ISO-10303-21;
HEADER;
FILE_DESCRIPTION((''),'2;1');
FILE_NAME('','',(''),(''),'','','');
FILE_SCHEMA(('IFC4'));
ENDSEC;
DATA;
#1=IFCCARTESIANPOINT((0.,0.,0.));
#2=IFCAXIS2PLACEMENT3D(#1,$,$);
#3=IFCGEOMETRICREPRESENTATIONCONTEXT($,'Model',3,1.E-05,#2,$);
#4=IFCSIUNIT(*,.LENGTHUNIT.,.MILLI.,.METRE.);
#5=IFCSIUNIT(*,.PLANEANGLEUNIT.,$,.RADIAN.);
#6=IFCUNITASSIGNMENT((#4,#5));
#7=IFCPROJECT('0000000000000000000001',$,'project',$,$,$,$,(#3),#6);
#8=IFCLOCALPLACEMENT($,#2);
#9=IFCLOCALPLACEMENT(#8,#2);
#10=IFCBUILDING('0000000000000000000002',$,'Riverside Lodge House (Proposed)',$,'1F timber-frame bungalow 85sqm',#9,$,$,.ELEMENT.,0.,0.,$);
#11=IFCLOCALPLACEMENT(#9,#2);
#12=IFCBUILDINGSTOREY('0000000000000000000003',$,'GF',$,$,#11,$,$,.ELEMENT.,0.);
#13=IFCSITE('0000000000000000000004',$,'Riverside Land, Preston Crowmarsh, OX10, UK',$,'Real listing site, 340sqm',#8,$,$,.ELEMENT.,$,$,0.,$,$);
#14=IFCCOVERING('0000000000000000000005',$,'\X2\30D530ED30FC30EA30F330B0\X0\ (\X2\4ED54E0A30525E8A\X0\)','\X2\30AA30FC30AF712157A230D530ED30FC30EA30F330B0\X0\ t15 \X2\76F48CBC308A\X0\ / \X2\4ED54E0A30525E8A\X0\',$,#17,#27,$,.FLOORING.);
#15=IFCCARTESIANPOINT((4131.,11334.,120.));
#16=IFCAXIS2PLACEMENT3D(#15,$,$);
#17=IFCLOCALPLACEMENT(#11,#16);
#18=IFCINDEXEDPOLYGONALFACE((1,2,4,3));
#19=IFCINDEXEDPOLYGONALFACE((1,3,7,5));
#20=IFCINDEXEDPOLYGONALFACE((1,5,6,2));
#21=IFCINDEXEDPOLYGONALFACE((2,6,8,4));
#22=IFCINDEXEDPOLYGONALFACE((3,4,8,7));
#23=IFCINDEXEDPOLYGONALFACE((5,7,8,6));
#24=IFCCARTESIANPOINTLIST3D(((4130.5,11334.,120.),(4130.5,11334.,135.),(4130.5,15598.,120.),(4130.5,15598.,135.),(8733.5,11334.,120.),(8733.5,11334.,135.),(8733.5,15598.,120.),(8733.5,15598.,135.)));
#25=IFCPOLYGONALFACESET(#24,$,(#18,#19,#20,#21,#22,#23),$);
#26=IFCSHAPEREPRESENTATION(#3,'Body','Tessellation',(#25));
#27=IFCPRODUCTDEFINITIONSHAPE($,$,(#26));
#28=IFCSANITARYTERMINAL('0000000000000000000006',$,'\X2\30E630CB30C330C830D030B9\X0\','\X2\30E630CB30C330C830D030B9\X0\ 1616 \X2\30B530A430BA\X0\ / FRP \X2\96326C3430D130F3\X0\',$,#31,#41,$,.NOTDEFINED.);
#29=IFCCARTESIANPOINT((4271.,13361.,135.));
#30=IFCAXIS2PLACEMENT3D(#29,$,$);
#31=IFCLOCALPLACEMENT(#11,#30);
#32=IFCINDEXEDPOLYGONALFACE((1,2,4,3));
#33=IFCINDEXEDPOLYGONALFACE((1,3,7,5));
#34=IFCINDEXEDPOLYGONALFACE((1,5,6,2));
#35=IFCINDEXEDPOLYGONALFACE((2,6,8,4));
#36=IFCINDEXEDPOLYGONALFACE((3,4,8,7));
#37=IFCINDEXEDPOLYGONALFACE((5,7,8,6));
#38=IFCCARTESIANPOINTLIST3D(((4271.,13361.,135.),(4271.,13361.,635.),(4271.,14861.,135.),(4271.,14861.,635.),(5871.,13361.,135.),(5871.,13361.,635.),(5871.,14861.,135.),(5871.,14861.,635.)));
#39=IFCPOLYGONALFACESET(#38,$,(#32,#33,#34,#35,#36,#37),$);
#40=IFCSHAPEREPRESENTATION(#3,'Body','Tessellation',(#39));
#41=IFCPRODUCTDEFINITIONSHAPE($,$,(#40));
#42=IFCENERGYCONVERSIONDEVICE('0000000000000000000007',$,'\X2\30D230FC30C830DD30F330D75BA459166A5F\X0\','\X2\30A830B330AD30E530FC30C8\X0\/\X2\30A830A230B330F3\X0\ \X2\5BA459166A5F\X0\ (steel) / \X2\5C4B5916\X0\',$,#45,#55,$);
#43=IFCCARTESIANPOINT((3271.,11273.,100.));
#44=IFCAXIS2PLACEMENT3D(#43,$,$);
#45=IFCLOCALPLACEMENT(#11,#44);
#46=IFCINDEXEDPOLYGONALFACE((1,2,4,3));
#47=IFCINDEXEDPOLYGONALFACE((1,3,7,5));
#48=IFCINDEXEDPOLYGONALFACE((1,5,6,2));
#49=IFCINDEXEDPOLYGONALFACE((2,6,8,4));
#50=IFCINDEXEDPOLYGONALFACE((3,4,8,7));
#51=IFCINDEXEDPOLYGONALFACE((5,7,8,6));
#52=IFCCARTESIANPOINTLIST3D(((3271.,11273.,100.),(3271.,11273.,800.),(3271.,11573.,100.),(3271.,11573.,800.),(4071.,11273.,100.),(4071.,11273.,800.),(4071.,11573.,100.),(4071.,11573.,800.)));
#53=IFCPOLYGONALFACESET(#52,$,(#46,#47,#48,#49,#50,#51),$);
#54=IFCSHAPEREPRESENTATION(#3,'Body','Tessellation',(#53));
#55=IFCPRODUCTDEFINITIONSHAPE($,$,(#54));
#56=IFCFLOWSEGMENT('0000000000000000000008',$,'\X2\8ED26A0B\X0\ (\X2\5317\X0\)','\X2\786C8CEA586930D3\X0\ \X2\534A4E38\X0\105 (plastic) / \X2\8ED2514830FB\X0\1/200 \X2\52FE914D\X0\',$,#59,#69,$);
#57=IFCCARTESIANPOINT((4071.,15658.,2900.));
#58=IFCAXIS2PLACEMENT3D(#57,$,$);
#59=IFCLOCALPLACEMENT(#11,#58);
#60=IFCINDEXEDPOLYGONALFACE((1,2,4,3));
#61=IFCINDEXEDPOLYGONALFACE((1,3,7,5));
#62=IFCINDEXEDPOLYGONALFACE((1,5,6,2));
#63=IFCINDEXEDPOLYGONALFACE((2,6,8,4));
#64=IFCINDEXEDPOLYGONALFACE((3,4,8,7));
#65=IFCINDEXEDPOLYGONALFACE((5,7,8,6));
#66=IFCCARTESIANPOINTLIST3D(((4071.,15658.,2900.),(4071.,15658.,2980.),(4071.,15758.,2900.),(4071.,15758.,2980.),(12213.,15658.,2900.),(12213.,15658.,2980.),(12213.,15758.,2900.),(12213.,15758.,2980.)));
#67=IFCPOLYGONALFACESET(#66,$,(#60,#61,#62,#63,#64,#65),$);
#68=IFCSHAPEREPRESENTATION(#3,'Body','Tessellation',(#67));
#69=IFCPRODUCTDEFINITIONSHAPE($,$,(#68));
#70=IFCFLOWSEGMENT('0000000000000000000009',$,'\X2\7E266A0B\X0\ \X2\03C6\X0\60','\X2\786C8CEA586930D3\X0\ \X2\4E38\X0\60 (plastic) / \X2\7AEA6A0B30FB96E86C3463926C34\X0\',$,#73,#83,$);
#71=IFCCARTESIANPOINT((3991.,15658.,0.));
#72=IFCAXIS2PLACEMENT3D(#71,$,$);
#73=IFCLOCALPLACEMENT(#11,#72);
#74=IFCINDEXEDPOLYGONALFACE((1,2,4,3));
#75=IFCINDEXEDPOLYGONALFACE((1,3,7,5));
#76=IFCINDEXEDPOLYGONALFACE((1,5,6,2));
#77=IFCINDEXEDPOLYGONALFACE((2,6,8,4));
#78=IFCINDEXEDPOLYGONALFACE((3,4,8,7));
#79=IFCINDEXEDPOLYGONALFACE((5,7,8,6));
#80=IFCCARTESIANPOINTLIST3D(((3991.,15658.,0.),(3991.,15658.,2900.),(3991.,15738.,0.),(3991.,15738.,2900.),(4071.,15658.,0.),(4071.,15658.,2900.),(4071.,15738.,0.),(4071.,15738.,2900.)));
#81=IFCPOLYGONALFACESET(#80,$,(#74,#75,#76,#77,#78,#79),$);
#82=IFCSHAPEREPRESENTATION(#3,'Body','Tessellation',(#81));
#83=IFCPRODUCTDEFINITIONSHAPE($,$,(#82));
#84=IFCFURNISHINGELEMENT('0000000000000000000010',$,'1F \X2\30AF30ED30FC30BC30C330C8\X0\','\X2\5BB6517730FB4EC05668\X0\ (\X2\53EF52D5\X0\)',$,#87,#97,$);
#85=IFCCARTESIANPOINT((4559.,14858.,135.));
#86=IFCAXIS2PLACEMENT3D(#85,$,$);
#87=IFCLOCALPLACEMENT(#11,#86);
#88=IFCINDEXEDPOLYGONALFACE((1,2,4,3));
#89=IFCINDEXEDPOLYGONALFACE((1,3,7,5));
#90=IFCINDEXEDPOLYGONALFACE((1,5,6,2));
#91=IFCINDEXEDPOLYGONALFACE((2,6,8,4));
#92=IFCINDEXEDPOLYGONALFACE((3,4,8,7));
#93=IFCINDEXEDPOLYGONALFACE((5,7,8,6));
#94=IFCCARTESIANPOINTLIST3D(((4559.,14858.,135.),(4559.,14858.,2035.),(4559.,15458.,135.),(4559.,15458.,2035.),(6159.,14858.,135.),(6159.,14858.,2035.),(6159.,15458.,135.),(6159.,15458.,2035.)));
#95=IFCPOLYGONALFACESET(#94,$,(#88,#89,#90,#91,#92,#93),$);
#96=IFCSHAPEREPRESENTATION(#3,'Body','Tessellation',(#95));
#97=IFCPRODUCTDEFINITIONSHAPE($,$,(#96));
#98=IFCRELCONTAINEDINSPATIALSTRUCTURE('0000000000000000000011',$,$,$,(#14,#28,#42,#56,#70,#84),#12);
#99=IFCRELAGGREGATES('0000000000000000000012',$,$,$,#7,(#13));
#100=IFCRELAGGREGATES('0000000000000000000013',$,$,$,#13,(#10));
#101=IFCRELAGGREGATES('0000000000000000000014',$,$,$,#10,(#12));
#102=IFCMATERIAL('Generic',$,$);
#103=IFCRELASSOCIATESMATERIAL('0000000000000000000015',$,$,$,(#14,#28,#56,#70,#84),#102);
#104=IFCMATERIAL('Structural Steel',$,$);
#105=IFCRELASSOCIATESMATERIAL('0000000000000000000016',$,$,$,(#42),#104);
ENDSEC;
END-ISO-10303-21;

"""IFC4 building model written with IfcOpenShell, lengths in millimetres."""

from ifc_helpers import new_model, si_unit, frame, frame_2d, origin, place, context, project, spatial, rectangle, extrude, material, element, save


model = new_model("IFC4")

# Units and contexts
model_context = context("Model", 3, precision=1e-05, world=origin())
ifc_project = project(units=[si_unit("LENGTHUNIT", "METRE", prefix="MILLI"), si_unit("PLANEANGLEUNIT", "RADIAN")], contexts=[model_context])

# Site, building, storey
site_placement = place(None, origin())
site = spatial("IfcSite", under=ifc_project, at=site_placement, Name="Riverside Land, Preston Crowmarsh, OX10, UK", ObjectType="Real listing site, 340sqm", CompositionType="ELEMENT", RefElevation=0.0)
building_placement = place(site_placement, origin())
building = spatial("IfcBuilding", under=site, at=building_placement, Name="Riverside Lodge House (Proposed)", ObjectType="1F timber-frame bungalow 85sqm", CompositionType="ELEMENT", ElevationOfRefHeight=0.0, ElevationOfTerrain=0.0)
storey_placement = place(building_placement, origin())
storey = spatial("IfcBuildingStorey", under=building, at=storey_placement, Name="GF", CompositionType="ELEMENT", Elevation=0.0)

# Shared definitions
ifc_material_1 = material(Name="Structural Steel")

# Covering
ifc_material_2 = material(Name="Generic")
covering_placement = place(storey_placement, frame((4131.0, 11334.0, 120.0)))
element("IfcCovering", 1, at=covering_placement, inside=storey, material=ifc_material_2, Name="フローリング (仕上げ床)", Description="オーク無垢フローリング t15 直貼り / 仕上げ床", PredefinedType="FLOORING", context=model_context, shape_type="SweptSolid", body=[
    extrude(rectangle(XDim=4603.0, YDim=4264.0, at=frame_2d((2301.0, 2132.0))), frame((4131.0, 11334.0, 120.0)), (0.0, 0.0, 1.0), 15.0),
])

# Sanitary terminal
sanitary_terminal_placement = place(storey_placement, frame((4271.0, 13361.0, 135.0)))
element("IfcSanitaryTerminal", 2, at=sanitary_terminal_placement, inside=storey, material=ifc_material_2, Name="ユニットバス", Description="ユニットバス 1616 サイズ / FRP 防水パン", PredefinedType="NOTDEFINED", context=model_context, shape_type="SweptSolid", body=[
    extrude(rectangle(XDim=1600.0, YDim=1500.0, at=frame_2d((800.0, 750.0))), frame((4271.0, 13361.0, 135.0)), (0.0, 0.0, 1.0), 500.0),
])

# Energy conversion device
energy_conversion_device_placement = place(storey_placement, frame((3271.0, 11273.0, 100.0)))
element("IfcEnergyConversionDevice", 3, at=energy_conversion_device_placement, inside=storey, material=ifc_material_1, Name="ヒートポンプ室外機", Description="エコキュート/エアコン 室外機 (steel) / 屋外", context=model_context, shape_type="SweptSolid", body=[
    extrude(rectangle(XDim=800.0, YDim=300.0, at=frame_2d((400.0, 150.0))), frame((3271.0, 11273.0, 100.0)), (0.0, 0.0, 1.0), 700.0),
])

# Flow segments
flow_segment_1_placement = place(storey_placement, frame((4071.0, 15658.0, 2900.0)))
element("IfcFlowSegment", 4, at=flow_segment_1_placement, inside=storey, material=ifc_material_2, Name="軒樋 (北)", Description="硬質塩ビ 半丸105 (plastic) / 軒先・1/200 勾配", context=model_context, shape_type="SweptSolid", body=[
    extrude(rectangle(XDim=8142.0, YDim=100.0, at=frame_2d((4071.0, 50.0))), frame((4071.0, 15658.0, 2900.0)), (0.0, 0.0, 1.0), 80.0),
])
flow_segment_2_placement = place(storey_placement, frame((3991.0, 15658.0, 0.0)))
element("IfcFlowSegment", 5, at=flow_segment_2_placement, inside=storey, material=ifc_material_2, Name="縦樋 φ60", Description="硬質塩ビ 丸60 (plastic) / 竪樋・雨水排水", context=model_context, shape_type="SweptSolid", body=[
    extrude(rectangle(XDim=80.0, YDim=80.0, at=frame_2d((40.0, 40.0))), frame((3991.0, 15658.0, 0.0)), (0.0, 0.0, 1.0), 2900.0),
])

# Furnishing element
furnishing_placement = place(storey_placement, frame((4559.0, 14858.0, 135.0)))
element("IfcFurnishingElement", 6, at=furnishing_placement, inside=storey, material=ifc_material_2, Name="1F クローゼット", Description="家具・什器 (可動)", context=model_context, shape_type="SweptSolid", body=[
    extrude(rectangle(XDim=1600.0, YDim=600.0, at=frame_2d((800.0, 300.0))), frame((4559.0, 14858.0, 135.0)), (0.0, 0.0, 1.0), 1900.0),
])

save(model, "model.ifc")
